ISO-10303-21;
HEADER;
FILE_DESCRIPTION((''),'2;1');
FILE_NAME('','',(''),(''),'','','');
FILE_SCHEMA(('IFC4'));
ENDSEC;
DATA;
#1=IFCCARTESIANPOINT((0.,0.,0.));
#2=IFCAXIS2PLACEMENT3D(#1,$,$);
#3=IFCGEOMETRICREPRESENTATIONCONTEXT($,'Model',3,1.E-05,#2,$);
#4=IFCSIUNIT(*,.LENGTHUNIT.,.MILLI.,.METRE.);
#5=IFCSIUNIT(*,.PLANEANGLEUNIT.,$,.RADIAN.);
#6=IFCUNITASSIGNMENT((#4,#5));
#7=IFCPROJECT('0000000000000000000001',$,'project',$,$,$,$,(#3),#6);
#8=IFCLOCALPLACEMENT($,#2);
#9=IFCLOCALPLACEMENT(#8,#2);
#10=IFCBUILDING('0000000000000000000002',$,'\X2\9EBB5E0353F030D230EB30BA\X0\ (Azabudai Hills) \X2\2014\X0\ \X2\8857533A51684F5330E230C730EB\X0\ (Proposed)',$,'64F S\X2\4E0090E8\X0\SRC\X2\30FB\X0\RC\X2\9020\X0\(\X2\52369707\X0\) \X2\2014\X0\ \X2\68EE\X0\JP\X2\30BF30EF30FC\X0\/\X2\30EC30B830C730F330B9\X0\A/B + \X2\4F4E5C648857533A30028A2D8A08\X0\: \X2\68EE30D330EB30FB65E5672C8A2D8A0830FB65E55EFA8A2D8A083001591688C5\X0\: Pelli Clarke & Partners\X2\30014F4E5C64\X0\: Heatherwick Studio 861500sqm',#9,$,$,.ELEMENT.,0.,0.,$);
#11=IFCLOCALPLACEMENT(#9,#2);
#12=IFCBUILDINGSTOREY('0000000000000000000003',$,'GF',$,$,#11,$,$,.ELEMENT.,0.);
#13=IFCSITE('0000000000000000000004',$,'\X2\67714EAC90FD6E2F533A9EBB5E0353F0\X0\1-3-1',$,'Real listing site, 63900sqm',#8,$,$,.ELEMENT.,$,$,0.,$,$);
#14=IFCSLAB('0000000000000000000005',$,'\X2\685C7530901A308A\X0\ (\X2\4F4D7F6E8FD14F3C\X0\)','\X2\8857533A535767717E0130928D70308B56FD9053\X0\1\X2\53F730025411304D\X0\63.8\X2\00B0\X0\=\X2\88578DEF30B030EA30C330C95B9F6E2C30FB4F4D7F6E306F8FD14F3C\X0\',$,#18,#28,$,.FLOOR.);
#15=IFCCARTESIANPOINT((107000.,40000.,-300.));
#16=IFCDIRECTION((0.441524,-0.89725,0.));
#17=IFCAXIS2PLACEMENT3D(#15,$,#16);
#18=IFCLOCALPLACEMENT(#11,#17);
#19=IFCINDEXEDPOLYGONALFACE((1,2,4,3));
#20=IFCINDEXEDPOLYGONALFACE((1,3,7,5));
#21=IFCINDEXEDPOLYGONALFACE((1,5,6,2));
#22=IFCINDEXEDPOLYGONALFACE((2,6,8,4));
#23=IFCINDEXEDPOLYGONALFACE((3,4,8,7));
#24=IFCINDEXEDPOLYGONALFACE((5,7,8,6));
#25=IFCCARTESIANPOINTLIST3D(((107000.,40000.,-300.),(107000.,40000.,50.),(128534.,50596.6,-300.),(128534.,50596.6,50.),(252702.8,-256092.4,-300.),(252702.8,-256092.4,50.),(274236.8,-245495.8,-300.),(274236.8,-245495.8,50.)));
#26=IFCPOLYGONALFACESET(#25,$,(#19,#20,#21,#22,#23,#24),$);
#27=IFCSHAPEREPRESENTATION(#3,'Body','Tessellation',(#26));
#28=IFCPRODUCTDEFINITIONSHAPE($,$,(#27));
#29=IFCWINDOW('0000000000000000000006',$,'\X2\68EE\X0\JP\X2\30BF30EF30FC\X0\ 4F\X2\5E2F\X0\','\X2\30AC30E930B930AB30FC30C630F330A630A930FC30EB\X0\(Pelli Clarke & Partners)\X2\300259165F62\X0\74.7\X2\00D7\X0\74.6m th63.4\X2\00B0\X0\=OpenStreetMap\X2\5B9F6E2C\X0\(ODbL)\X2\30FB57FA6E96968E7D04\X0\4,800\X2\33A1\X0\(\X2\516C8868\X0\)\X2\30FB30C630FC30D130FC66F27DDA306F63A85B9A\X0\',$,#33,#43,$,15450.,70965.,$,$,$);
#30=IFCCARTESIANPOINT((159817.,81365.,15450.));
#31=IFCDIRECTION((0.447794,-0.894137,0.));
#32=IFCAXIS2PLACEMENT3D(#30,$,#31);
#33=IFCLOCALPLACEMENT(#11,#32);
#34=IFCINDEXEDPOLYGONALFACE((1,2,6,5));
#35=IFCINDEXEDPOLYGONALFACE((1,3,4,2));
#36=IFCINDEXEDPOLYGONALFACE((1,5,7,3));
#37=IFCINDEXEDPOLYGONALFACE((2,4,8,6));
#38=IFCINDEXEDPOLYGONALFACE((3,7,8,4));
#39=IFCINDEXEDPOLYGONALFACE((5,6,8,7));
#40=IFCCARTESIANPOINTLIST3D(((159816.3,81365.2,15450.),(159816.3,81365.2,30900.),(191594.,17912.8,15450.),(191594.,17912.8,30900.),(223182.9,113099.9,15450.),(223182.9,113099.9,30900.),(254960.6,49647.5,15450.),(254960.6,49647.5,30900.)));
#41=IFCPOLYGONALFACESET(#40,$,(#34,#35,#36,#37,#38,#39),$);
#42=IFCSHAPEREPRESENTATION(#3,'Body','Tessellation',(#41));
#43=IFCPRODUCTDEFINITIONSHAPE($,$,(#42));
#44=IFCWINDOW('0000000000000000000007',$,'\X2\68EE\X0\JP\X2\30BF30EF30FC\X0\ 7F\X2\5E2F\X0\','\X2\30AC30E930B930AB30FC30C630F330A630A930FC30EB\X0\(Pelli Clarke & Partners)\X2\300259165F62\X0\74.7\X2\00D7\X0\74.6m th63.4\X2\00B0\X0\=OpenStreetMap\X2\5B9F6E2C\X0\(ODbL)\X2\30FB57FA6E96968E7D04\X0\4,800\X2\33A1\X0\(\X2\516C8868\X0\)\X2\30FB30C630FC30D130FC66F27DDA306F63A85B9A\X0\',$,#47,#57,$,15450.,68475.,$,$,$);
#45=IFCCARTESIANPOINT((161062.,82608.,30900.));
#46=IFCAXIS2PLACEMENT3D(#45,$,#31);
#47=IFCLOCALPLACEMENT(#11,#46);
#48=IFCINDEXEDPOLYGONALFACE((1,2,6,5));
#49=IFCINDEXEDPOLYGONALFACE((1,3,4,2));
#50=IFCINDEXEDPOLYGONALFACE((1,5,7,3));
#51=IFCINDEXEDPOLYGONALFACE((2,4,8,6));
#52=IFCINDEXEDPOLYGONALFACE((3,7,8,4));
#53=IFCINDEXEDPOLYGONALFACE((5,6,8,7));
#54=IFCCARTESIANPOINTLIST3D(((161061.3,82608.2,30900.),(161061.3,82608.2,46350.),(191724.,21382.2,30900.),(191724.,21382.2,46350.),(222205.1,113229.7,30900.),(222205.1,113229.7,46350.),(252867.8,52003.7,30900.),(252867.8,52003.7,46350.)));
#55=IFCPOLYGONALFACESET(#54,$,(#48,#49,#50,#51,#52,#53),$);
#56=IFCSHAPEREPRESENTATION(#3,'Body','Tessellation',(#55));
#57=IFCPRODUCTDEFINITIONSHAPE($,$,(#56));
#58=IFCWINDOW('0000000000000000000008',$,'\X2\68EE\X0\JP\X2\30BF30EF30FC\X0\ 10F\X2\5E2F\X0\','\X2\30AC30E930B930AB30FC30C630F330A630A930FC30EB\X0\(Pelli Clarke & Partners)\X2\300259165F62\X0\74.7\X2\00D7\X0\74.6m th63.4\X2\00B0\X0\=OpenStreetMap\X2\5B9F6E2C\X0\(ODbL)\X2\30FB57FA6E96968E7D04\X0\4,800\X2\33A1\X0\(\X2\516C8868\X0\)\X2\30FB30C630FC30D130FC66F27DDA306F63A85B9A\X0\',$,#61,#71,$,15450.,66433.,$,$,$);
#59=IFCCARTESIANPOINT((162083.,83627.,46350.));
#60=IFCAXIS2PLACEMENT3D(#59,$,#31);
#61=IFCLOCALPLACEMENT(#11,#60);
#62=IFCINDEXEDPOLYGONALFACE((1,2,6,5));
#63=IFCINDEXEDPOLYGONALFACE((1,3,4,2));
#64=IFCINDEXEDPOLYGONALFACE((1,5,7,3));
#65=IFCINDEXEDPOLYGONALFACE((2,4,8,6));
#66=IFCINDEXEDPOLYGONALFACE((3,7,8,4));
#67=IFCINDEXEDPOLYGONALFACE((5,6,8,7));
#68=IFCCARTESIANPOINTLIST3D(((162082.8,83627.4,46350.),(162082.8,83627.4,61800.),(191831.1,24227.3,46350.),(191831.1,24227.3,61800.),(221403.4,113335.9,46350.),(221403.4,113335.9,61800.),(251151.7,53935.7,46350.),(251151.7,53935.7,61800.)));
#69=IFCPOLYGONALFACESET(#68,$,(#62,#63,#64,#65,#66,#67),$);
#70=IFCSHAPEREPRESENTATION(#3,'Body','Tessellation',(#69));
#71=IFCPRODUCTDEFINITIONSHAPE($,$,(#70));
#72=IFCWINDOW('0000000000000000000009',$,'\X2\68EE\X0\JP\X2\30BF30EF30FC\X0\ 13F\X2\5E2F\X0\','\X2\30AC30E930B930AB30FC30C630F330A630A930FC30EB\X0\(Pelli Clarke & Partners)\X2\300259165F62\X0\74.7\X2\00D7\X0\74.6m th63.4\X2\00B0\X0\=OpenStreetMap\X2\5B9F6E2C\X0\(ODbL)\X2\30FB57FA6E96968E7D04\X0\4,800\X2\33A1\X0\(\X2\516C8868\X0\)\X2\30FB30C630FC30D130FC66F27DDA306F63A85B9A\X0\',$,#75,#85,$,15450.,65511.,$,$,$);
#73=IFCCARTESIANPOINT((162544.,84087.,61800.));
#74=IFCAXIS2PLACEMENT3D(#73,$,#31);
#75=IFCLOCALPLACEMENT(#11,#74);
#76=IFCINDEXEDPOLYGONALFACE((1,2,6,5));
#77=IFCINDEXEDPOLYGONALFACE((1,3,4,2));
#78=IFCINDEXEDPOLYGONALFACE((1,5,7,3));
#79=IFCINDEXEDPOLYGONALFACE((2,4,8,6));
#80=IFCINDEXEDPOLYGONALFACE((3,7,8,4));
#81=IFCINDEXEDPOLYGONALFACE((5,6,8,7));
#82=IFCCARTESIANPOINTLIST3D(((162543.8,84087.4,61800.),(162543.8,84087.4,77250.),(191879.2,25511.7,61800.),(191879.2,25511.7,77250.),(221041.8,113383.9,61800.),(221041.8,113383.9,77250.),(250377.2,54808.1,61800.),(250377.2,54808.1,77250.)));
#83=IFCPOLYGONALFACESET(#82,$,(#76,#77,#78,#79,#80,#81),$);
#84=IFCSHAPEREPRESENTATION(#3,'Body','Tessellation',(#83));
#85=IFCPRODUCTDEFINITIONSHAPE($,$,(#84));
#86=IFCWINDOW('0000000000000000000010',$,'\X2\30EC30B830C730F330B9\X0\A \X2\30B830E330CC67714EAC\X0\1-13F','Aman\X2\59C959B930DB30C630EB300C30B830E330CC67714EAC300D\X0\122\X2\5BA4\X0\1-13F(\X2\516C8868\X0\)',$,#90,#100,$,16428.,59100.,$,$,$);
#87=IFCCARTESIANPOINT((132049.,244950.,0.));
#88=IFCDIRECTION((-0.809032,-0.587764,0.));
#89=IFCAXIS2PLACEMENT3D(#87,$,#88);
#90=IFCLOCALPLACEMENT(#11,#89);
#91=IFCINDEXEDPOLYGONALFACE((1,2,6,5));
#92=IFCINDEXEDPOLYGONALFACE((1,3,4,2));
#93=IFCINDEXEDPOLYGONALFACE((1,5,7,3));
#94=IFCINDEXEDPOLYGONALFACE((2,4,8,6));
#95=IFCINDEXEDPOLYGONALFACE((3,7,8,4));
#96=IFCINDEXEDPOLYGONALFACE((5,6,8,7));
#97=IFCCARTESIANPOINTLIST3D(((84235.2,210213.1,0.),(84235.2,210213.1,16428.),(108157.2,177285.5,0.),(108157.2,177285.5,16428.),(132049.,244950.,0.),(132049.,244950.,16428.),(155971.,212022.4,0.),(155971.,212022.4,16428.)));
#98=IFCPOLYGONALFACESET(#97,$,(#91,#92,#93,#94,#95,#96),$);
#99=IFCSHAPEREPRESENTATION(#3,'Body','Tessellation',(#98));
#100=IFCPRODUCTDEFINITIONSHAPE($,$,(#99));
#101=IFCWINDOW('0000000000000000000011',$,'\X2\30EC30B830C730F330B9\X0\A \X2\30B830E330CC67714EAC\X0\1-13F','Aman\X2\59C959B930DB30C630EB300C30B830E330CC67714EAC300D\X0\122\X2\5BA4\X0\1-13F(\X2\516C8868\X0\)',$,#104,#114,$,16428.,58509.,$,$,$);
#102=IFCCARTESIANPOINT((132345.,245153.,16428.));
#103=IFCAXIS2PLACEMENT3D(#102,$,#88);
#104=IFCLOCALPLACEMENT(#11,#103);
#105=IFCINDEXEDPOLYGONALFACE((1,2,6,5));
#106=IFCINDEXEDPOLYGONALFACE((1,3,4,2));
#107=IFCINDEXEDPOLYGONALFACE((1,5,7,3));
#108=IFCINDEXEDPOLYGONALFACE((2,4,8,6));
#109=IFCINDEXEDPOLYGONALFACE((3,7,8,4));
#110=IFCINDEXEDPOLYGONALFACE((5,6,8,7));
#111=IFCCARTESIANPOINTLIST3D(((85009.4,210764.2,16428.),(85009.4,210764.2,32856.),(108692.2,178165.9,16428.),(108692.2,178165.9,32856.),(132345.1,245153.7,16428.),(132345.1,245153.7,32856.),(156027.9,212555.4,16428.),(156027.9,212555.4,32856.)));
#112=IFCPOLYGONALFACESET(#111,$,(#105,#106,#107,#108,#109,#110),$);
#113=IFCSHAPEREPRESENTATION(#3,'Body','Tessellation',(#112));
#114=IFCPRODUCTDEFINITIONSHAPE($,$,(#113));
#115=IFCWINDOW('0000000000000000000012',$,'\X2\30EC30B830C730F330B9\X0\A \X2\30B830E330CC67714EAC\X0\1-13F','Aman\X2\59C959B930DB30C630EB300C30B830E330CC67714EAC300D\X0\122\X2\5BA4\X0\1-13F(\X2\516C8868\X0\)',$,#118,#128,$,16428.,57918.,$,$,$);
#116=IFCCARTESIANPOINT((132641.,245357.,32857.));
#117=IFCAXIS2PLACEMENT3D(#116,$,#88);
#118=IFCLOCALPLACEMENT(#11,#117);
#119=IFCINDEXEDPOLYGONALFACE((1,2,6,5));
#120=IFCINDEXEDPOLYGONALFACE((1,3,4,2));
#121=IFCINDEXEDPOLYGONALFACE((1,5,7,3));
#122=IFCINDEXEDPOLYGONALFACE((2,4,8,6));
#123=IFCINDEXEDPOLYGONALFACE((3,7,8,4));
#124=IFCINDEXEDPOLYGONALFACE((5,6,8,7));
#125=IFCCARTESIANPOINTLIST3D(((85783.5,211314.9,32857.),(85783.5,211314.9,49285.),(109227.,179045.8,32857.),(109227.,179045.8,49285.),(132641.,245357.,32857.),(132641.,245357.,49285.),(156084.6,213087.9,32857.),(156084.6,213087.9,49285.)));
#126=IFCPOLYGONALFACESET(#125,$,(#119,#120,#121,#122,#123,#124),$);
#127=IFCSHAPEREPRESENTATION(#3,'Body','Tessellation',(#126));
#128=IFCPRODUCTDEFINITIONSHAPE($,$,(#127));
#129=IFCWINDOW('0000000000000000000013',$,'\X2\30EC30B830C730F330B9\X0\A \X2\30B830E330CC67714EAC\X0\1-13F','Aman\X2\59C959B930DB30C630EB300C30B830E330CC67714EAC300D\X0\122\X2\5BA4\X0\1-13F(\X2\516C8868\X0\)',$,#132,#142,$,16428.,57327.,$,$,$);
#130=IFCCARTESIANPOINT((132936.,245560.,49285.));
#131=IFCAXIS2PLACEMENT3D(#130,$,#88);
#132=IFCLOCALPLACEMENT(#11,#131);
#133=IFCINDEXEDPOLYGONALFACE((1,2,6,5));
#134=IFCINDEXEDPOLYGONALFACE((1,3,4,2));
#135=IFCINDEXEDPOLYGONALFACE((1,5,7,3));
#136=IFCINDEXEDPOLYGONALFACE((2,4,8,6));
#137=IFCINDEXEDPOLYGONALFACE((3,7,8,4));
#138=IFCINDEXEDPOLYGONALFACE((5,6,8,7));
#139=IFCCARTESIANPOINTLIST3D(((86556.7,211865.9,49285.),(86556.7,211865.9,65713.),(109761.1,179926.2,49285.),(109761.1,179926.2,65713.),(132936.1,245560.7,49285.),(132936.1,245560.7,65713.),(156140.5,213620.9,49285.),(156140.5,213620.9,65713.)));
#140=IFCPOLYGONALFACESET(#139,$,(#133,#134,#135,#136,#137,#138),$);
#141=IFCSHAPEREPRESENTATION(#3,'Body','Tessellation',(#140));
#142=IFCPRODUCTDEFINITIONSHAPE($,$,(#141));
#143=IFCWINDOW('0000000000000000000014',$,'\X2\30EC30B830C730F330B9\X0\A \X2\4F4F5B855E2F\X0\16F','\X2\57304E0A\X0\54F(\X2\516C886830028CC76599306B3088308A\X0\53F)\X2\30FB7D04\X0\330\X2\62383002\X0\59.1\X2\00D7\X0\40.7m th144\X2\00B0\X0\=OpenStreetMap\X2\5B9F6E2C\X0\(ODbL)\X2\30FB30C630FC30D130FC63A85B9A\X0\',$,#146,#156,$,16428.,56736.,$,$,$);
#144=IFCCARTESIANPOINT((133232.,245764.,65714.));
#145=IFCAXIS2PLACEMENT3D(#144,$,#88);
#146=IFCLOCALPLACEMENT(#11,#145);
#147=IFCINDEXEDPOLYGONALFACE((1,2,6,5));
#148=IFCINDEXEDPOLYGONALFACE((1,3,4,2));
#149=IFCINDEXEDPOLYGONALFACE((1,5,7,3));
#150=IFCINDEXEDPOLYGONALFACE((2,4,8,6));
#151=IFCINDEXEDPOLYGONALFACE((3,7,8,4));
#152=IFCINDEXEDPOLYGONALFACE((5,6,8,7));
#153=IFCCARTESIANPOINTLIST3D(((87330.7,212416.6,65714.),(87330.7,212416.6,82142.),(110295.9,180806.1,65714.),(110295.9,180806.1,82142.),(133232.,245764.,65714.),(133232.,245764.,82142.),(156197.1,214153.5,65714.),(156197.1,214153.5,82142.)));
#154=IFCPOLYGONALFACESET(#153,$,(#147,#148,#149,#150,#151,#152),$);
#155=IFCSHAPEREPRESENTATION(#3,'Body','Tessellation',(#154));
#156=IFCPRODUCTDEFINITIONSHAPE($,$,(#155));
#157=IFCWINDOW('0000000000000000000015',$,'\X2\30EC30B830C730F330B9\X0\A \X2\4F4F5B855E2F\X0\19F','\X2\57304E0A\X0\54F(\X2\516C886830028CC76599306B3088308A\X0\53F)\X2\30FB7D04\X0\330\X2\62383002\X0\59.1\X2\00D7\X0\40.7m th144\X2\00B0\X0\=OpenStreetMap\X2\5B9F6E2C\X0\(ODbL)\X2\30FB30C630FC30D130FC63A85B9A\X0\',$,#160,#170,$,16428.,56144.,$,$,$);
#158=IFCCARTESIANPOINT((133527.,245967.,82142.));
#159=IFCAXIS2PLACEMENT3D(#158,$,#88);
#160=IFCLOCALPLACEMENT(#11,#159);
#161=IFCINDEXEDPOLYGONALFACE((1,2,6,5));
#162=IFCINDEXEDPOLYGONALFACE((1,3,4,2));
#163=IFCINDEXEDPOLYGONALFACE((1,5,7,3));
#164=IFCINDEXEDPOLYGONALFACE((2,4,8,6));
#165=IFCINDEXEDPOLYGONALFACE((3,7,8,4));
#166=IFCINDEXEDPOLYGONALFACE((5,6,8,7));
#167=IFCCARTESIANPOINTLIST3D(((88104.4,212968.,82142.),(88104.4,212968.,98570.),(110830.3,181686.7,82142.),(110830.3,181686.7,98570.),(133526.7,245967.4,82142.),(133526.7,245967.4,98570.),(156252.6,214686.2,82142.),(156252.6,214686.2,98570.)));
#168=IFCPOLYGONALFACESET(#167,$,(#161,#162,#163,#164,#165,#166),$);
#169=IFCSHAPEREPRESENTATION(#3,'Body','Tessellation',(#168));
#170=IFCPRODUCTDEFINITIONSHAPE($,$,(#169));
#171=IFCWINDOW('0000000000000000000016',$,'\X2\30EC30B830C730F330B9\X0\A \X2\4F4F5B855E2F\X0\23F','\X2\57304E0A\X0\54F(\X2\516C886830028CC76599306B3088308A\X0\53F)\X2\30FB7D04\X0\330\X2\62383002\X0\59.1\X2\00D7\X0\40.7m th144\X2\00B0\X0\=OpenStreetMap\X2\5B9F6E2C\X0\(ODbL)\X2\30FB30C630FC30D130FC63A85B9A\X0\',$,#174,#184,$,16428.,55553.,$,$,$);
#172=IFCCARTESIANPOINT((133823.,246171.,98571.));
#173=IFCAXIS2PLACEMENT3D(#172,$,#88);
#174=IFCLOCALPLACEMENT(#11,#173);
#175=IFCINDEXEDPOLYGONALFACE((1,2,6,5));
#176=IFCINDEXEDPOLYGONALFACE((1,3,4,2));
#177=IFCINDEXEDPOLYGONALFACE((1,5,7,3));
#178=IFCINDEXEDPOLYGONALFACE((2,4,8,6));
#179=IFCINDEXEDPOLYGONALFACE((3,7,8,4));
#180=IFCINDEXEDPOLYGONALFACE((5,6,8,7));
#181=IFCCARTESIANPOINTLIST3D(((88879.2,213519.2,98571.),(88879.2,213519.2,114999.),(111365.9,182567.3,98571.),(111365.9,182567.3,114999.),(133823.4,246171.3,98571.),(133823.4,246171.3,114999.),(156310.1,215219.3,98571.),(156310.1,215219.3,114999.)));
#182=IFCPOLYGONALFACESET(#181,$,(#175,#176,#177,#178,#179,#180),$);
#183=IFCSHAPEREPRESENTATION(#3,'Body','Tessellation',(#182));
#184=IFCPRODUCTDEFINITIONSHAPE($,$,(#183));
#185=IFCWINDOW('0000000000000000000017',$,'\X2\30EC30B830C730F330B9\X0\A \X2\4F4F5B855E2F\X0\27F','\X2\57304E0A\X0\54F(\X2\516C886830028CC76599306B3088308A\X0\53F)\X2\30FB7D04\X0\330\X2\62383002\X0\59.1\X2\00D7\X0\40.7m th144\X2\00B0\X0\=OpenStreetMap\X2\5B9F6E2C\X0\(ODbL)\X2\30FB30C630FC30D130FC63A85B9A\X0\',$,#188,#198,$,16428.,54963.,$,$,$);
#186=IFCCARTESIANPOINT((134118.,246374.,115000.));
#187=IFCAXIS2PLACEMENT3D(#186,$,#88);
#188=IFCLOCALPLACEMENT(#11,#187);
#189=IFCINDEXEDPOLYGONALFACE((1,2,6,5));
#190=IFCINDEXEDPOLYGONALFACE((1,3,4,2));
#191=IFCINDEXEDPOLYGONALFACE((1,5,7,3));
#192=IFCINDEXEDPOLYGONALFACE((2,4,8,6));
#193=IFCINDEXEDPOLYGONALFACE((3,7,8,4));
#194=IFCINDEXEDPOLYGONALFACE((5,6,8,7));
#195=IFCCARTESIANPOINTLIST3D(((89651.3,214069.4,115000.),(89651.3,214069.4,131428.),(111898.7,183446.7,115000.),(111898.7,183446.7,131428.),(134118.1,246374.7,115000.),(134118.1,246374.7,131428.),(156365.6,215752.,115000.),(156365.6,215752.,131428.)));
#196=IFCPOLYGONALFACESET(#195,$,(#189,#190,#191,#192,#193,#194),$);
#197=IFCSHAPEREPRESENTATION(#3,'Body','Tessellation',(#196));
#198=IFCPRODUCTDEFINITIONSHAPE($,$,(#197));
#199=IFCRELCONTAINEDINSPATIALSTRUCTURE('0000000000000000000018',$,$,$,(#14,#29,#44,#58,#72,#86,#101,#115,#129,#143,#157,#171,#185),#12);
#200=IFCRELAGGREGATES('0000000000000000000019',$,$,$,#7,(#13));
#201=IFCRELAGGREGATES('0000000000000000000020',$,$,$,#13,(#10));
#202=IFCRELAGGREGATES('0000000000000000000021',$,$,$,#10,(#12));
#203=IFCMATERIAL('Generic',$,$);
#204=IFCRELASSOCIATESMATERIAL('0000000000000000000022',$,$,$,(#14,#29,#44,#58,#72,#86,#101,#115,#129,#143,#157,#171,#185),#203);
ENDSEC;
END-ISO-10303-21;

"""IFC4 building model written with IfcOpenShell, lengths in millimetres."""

from ifc_helpers import new_model, si_unit, frame, frame_2d, origin, place, context, project, spatial, rectangle, extrude, material, element, save


model = new_model("IFC4")

# Units and contexts
model_context = context("Model", 3, precision=1e-05, world=origin())
ifc_project = project(units=[si_unit("LENGTHUNIT", "METRE", prefix="MILLI"), si_unit("PLANEANGLEUNIT", "RADIAN")], contexts=[model_context])

# Site, building, storey
site_placement = place(None, origin())
site = spatial("IfcSite", under=ifc_project, at=site_placement, Name="東京都港区麻布台1-3-1", ObjectType="Real listing site, 63900sqm", CompositionType="ELEMENT", RefElevation=0.0)
building_placement = place(site_placement, origin())
building = spatial("IfcBuilding", under=site, at=building_placement, Name="麻布台ヒルズ (Azabudai Hills) — 街区全体モデル (Proposed)", ObjectType="64F S一部SRC・RC造(制震) — 森JPタワー/レジデンスA/B + 低層街区。設計: 森ビル・日本設計・日建設計、外装: Pelli Clarke & Partners、低層: Heatherwick Studio 861500sqm", CompositionType="ELEMENT", ElevationOfRefHeight=0.0, ElevationOfTerrain=0.0)
storey_placement = place(building_placement, origin())
storey = spatial("IfcBuildingStorey", under=building, at=storey_placement, Name="GF", CompositionType="ELEMENT", Elevation=0.0)

# Slab
ifc_material = material(Name="Generic")
slab_1_placement = place(storey_placement, frame((107000.0, 40000.0, -300.0), x_axis=(0.441524, -0.89725, 0.0)))
element("IfcSlab", 1, at=slab_1_placement, inside=storey, material=ifc_material, Name="桜田通り (位置近似)", Description="街区南東縁を走る国道1号。向き63.8°=街路グリッド実測・位置は近似", PredefinedType="FLOOR", context=model_context, shape_type="SweptSolid", body=[
    extrude(rectangle(XDim=330000.0, YDim=24000.0, at=frame_2d((165000.0, 12000.0))), frame((107000.0, 40000.0, -300.0), x_axis=(0.441524, -0.89725, 0.0)), (0.0, 0.0, 1.0), 350.0),
])

# Windows
window_1_placement = place(storey_placement, frame((159817.0, 81365.0, 15450.0), x_axis=(0.447794, -0.894137, 0.0)))
element("IfcWindow", 2, at=window_1_placement, inside=storey, material=ifc_material, Name="森JPタワー 4F帯", Description="ガラスカーテンウォール(Pelli Clarke & Partners)。外形74.7×74.6m th63.4°=OpenStreetMap実測(ODbL)・基準階約4,800㎡(公表)・テーパー曲線は推定", OverallHeight=15450.0, OverallWidth=70965.0, context=model_context, shape_type="SweptSolid", body=[
    extrude(rectangle(XDim=70965.0, YDim=70869.0, at=frame_2d((35482.0, 35434.0))), frame((159817.0, 81365.0, 15450.0), x_axis=(0.447794, -0.894137, 0.0)), (0.0, 0.0, 1.0), 15450.0),
])
window_2_placement = place(storey_placement, frame((161062.0, 82608.0, 30900.0), x_axis=(0.447794, -0.894137, 0.0)))
element("IfcWindow", 3, at=window_2_placement, inside=storey, material=ifc_material, Name="森JPタワー 7F帯", Description="ガラスカーテンウォール(Pelli Clarke & Partners)。外形74.7×74.6m th63.4°=OpenStreetMap実測(ODbL)・基準階約4,800㎡(公表)・テーパー曲線は推定", OverallHeight=15450.0, OverallWidth=68475.0, context=model_context, shape_type="SweptSolid", body=[
    extrude(rectangle(XDim=68475.0, YDim=68383.0, at=frame_2d((34237.0, 34191.0))), frame((161062.0, 82608.0, 30900.0), x_axis=(0.447794, -0.894137, 0.0)), (0.0, 0.0, 1.0), 15450.0),
])
window_3_placement = place(storey_placement, frame((162083.0, 83627.0, 46350.0), x_axis=(0.447794, -0.894137, 0.0)))
element("IfcWindow", 4, at=window_3_placement, inside=storey, material=ifc_material, Name="森JPタワー 10F帯", Description="ガラスカーテンウォール(Pelli Clarke & Partners)。外形74.7×74.6m th63.4°=OpenStreetMap実測(ODbL)・基準階約4,800㎡(公表)・テーパー曲線は推定", OverallHeight=15450.0, OverallWidth=66433.0, context=model_context, shape_type="SweptSolid", body=[
    extrude(rectangle(XDim=66433.0, YDim=66344.0, at=frame_2d((33216.0, 33172.0))), frame((162083.0, 83627.0, 46350.0), x_axis=(0.447794, -0.894137, 0.0)), (0.0, 0.0, 1.0), 15450.0),
])
window_4_placement = place(storey_placement, frame((162544.0, 84087.0, 61800.0), x_axis=(0.447794, -0.894137, 0.0)))
element("IfcWindow", 5, at=window_4_placement, inside=storey, material=ifc_material, Name="森JPタワー 13F帯", Description="ガラスカーテンウォール(Pelli Clarke & Partners)。外形74.7×74.6m th63.4°=OpenStreetMap実測(ODbL)・基準階約4,800㎡(公表)・テーパー曲線は推定", OverallHeight=15450.0, OverallWidth=65511.0, context=model_context, shape_type="SweptSolid", body=[
    extrude(rectangle(XDim=65511.0, YDim=65424.0, at=frame_2d((32755.0, 32712.0))), frame((162544.0, 84087.0, 61800.0), x_axis=(0.447794, -0.894137, 0.0)), (0.0, 0.0, 1.0), 15450.0),
])
window_5_placement = place(storey_placement, frame((132049.0, 244950.0, 0.0), x_axis=(-0.809032, -0.587764, 0.0)))
element("IfcWindow", 6, at=window_5_placement, inside=storey, material=ifc_material, Name="レジデンスA ジャヌ東京1-13F", Description="Aman姉妹ホテル「ジャヌ東京」122室1-13F(公表)", OverallHeight=16428.0, OverallWidth=59100.0, context=model_context, shape_type="SweptSolid", body=[
    extrude(rectangle(XDim=59100.0, YDim=40700.0, at=frame_2d((29550.0, 20350.0))), frame((132049.0, 244950.0, 0.0), x_axis=(-0.809032, -0.587764, 0.0)), (0.0, 0.0, 1.0), 16428.0),
])
window_6_placement = place(storey_placement, frame((132345.0, 245153.0, 16428.0), x_axis=(-0.809032, -0.587764, 0.0)))
element("IfcWindow", 7, at=window_6_placement, inside=storey, material=ifc_material, Name="レジデンスA ジャヌ東京1-13F", Description="Aman姉妹ホテル「ジャヌ東京」122室1-13F(公表)", OverallHeight=16428.0, OverallWidth=58509.0, context=model_context, shape_type="SweptSolid", body=[
    extrude(rectangle(XDim=58509.0, YDim=40293.0, at=frame_2d((29254.0, 20146.0))), frame((132345.0, 245153.0, 16428.0), x_axis=(-0.809032, -0.587764, 0.0)), (0.0, 0.0, 1.0), 16428.0),
])
window_7_placement = place(storey_placement, frame((132641.0, 245357.0, 32857.0), x_axis=(-0.809032, -0.587764, 0.0)))
element("IfcWindow", 8, at=window_7_placement, inside=storey, material=ifc_material, Name="レジデンスA ジャヌ東京1-13F", Description="Aman姉妹ホテル「ジャヌ東京」122室1-13F(公表)", OverallHeight=16428.0, OverallWidth=57918.0, context=model_context, shape_type="SweptSolid", body=[
    extrude(rectangle(XDim=57918.0, YDim=39886.0, at=frame_2d((28959.0, 19943.0))), frame((132641.0, 245357.0, 32857.0), x_axis=(-0.809032, -0.587764, 0.0)), (0.0, 0.0, 1.0), 16428.0),
])
window_8_placement = place(storey_placement, frame((132936.0, 245560.0, 49285.0), x_axis=(-0.809032, -0.587764, 0.0)))
element("IfcWindow", 9, at=window_8_placement, inside=storey, material=ifc_material, Name="レジデンスA ジャヌ東京1-13F", Description="Aman姉妹ホテル「ジャヌ東京」122室1-13F(公表)", OverallHeight=16428.0, OverallWidth=57327.0, context=model_context, shape_type="SweptSolid", body=[
    extrude(rectangle(XDim=57327.0, YDim=39479.0, at=frame_2d((28663.0, 19739.0))), frame((132936.0, 245560.0, 49285.0), x_axis=(-0.809032, -0.587764, 0.0)), (0.0, 0.0, 1.0), 16428.0),
])
window_9_placement = place(storey_placement, frame((133232.0, 245764.0, 65714.0), x_axis=(-0.809032, -0.587764, 0.0)))
element("IfcWindow", 10, at=window_9_placement, inside=storey, material=ifc_material, Name="レジデンスA 住宅帯16F", Description="地上54F(公表。資料により53F)・約330戸。59.1×40.7m th144°=OpenStreetMap実測(ODbL)・テーパー推定", OverallHeight=16428.0, OverallWidth=56736.0, context=model_context, shape_type="SweptSolid", body=[
    extrude(rectangle(XDim=56736.0, YDim=39072.0, at=frame_2d((28368.0, 19536.0))), frame((133232.0, 245764.0, 65714.0), x_axis=(-0.809032, -0.587764, 0.0)), (0.0, 0.0, 1.0), 16428.0),
])
window_10_placement = place(storey_placement, frame((133527.0, 245967.0, 82142.0), x_axis=(-0.809032, -0.587764, 0.0)))
element("IfcWindow", 11, at=window_10_placement, inside=storey, material=ifc_material, Name="レジデンスA 住宅帯19F", Description="地上54F(公表。資料により53F)・約330戸。59.1×40.7m th144°=OpenStreetMap実測(ODbL)・テーパー推定", OverallHeight=16428.0, OverallWidth=56144.0, context=model_context, shape_type="SweptSolid", body=[
    extrude(rectangle(XDim=56144.0, YDim=38665.0, at=frame_2d((28072.0, 19332.0))), frame((133527.0, 245967.0, 82142.0), x_axis=(-0.809032, -0.587764, 0.0)), (0.0, 0.0, 1.0), 16428.0),
])
window_11_placement = place(storey_placement, frame((133823.0, 246171.0, 98571.0), x_axis=(-0.809032, -0.587764, 0.0)))
element("IfcWindow", 12, at=window_11_placement, inside=storey, material=ifc_material, Name="レジデンスA 住宅帯23F", Description="地上54F(公表。資料により53F)・約330戸。59.1×40.7m th144°=OpenStreetMap実測(ODbL)・テーパー推定", OverallHeight=16428.0, OverallWidth=55553.0, context=model_context, shape_type="SweptSolid", body=[
    extrude(rectangle(XDim=55553.0, YDim=38258.0, at=frame_2d((27776.0, 19129.0))), frame((133823.0, 246171.0, 98571.0), x_axis=(-0.809032, -0.587764, 0.0)), (0.0, 0.0, 1.0), 16428.0),
])
window_12_placement = place(storey_placement, frame((134118.0, 246374.0, 115000.0), x_axis=(-0.809032, -0.587764, 0.0)))
element("IfcWindow", 13, at=window_12_placement, inside=storey, material=ifc_material, Name="レジデンスA 住宅帯27F", Description="地上54F(公表。資料により53F)・約330戸。59.1×40.7m th144°=OpenStreetMap実測(ODbL)・テーパー推定", OverallHeight=16428.0, OverallWidth=54963.0, context=model_context, shape_type="SweptSolid", body=[
    extrude(rectangle(XDim=54963.0, YDim=37851.0, at=frame_2d((27481.0, 18925.0))), frame((134118.0, 246374.0, 115000.0), x_axis=(-0.809032, -0.587764, 0.0)), (0.0, 0.0, 1.0), 16428.0),
])

save(model, "model.ifc")
